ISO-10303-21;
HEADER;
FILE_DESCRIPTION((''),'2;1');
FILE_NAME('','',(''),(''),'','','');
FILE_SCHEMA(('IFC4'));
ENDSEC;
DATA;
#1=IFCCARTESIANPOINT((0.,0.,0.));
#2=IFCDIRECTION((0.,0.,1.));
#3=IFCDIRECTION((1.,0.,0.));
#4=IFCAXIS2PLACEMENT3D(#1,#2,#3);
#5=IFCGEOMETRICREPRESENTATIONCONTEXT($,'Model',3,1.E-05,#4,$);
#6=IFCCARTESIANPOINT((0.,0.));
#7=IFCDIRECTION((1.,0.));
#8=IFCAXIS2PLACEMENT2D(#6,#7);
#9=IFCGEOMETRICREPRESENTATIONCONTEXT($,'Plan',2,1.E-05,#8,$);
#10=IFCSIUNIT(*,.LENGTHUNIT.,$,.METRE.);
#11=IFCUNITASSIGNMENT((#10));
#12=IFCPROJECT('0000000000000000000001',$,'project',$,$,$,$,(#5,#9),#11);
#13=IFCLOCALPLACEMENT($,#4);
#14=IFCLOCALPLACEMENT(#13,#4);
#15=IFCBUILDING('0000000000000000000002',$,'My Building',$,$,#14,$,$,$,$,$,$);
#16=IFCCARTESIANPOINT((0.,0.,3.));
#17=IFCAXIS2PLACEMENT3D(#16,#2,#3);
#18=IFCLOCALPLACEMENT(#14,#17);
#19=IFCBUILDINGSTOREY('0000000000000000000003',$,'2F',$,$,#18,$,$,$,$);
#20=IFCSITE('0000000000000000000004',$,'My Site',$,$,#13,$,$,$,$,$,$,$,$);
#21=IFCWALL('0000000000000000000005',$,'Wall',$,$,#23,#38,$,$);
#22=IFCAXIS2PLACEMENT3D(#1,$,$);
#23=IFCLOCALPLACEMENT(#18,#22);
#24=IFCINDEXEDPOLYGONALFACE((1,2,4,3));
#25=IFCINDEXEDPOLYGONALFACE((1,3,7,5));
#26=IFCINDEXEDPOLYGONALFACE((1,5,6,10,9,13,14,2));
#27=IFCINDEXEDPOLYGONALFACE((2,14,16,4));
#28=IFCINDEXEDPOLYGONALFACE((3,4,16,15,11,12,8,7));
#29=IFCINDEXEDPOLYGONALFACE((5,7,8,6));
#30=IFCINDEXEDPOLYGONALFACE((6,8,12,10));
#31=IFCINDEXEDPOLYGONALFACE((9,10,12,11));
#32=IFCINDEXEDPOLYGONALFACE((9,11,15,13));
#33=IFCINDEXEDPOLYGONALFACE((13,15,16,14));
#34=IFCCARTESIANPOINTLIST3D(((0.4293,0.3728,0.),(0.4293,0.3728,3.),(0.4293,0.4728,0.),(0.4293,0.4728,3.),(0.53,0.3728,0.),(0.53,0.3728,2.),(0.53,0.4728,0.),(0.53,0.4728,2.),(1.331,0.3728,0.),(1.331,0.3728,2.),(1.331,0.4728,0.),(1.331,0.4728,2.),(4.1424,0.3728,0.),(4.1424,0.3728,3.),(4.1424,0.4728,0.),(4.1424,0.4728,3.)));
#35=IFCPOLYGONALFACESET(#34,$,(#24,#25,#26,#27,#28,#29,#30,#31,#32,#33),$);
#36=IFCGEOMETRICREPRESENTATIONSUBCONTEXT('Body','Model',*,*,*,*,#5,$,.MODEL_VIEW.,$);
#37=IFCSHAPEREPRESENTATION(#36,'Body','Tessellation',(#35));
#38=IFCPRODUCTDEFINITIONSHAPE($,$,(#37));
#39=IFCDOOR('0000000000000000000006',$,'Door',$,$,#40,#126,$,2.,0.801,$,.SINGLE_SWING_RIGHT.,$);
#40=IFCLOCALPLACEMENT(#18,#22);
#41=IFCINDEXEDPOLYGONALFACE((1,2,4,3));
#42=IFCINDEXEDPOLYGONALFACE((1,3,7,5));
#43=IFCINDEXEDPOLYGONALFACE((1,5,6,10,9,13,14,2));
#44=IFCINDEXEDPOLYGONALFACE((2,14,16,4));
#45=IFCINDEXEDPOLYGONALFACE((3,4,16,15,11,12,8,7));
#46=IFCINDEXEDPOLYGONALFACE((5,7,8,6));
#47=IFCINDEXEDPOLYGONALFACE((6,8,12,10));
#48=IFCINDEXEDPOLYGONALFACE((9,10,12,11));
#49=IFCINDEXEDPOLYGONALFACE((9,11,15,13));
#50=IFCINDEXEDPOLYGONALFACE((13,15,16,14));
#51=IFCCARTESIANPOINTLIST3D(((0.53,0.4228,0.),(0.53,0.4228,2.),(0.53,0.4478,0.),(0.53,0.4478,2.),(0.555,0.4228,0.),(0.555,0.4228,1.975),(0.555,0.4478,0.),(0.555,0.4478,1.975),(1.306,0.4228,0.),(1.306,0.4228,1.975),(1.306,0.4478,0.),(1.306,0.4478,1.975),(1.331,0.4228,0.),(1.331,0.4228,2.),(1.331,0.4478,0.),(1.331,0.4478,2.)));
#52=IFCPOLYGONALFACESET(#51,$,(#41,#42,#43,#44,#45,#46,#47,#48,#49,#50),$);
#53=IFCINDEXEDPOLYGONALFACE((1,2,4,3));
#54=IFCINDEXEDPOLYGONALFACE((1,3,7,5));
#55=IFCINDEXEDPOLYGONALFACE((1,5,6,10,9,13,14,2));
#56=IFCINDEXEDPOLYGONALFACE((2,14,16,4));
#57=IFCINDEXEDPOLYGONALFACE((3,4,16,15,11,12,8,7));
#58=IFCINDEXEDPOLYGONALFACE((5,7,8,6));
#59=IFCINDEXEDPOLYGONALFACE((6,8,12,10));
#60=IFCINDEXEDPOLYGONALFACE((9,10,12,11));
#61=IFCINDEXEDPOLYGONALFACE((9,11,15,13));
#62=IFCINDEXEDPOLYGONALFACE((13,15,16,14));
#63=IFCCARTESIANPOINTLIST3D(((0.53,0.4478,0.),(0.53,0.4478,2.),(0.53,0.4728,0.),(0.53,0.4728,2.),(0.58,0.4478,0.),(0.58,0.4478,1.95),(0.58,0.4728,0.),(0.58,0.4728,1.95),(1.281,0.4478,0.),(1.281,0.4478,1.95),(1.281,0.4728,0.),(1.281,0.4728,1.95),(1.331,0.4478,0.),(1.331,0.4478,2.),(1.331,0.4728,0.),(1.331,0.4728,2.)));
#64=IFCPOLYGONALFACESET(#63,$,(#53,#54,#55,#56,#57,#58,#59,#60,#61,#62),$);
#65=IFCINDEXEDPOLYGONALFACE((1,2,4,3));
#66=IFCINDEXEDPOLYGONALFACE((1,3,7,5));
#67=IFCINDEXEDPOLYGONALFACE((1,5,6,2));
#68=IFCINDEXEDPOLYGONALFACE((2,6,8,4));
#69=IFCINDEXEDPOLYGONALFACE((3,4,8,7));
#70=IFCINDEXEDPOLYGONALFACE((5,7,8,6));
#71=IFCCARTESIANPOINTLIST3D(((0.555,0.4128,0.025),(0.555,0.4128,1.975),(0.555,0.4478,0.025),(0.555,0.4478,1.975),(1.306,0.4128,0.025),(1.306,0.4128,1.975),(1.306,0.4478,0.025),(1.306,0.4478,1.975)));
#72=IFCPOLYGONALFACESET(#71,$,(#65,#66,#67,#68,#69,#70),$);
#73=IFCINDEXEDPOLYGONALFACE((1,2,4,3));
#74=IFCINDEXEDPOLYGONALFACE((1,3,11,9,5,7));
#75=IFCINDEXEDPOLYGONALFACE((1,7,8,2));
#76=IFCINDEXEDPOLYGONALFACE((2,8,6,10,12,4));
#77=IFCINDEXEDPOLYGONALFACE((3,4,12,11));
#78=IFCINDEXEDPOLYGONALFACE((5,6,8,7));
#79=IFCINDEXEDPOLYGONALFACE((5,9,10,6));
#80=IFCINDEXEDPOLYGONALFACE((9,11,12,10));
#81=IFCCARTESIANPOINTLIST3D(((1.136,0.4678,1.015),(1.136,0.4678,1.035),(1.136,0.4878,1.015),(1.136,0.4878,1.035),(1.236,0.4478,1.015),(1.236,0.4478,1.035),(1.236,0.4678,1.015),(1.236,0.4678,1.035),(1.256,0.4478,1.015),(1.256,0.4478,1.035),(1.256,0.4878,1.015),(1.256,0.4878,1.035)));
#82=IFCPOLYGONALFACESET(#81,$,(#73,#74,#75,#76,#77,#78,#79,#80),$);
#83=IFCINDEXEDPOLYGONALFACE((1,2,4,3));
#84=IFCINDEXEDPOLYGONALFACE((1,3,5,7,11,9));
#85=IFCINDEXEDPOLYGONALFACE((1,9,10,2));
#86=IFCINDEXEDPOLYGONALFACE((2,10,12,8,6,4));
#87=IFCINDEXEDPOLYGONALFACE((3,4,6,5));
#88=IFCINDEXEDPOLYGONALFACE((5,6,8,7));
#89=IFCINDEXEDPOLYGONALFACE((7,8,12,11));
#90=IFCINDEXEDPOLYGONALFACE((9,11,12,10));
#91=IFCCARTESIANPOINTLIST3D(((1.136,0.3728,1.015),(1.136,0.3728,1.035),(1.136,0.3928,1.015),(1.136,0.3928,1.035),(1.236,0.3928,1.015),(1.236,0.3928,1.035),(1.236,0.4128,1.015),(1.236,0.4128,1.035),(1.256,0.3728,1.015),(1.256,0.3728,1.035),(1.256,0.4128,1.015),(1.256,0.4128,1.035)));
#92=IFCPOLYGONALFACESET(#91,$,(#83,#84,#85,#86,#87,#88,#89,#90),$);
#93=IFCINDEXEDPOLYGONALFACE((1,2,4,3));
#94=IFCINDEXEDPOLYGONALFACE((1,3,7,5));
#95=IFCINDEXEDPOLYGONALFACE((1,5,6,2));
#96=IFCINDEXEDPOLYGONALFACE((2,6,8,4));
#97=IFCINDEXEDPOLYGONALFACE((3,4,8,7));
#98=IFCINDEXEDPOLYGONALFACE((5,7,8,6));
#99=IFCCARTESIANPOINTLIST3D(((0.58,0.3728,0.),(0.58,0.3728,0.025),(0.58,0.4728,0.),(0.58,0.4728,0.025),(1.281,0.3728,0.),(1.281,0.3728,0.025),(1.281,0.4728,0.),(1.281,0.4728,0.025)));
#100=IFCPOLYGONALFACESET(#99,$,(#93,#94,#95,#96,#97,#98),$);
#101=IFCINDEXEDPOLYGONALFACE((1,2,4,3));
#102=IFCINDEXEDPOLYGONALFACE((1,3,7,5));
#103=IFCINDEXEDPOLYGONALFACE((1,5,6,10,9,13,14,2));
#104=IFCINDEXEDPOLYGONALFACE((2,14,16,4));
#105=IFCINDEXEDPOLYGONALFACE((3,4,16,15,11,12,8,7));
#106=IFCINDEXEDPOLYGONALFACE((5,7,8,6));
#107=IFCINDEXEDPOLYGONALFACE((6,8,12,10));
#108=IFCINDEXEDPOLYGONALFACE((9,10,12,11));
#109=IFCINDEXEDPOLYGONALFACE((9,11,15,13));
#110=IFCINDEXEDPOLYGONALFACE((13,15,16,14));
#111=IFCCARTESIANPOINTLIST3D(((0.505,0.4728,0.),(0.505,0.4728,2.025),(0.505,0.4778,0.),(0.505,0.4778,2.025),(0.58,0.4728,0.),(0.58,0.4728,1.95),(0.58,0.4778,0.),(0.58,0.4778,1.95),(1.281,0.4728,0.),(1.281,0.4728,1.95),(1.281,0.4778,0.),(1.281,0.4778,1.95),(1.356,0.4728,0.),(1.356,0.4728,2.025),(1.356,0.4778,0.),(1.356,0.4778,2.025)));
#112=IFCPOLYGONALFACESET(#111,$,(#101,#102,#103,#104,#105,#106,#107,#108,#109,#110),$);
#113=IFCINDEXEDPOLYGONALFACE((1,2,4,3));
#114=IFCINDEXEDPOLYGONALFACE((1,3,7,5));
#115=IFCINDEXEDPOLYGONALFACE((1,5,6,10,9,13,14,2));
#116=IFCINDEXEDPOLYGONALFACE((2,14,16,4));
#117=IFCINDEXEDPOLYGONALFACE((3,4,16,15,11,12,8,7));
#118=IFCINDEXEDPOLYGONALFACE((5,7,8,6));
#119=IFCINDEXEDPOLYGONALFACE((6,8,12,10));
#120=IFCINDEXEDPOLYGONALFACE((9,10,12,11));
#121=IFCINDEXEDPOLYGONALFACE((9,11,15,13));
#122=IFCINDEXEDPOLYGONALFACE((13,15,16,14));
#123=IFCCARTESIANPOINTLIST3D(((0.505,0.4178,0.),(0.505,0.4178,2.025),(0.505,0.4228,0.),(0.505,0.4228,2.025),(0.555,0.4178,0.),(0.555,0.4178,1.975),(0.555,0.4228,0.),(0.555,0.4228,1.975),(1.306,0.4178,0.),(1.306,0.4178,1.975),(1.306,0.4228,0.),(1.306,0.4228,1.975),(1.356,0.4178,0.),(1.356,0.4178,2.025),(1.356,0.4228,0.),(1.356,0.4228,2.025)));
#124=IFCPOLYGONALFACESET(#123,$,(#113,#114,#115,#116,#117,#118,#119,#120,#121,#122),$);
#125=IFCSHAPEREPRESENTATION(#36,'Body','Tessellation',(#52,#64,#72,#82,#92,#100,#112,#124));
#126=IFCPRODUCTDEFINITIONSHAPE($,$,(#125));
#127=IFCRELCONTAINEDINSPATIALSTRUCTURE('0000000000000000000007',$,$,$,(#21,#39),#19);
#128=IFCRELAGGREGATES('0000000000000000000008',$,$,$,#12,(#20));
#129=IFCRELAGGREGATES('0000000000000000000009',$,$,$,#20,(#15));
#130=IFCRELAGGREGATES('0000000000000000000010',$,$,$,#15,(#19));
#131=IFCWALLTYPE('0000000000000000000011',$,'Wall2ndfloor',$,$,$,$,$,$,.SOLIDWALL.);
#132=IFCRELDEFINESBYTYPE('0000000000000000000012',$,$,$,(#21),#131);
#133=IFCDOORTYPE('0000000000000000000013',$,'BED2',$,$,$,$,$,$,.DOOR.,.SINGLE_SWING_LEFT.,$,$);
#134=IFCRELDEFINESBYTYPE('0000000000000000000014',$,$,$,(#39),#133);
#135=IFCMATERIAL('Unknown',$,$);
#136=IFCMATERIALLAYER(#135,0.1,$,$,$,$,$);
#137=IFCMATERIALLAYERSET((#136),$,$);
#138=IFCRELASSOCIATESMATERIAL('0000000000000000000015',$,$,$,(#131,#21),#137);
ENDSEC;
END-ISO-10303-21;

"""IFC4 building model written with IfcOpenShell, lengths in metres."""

from ifc_helpers import new_model, entity, si_unit, frame, origin_with_axes, origin_2d_with_axis, place, context, subcontext, project, spatial, line, indexed_curve, outline, extrude, shape, source, transform, mapped, material, layer, layer_set, layer_usage, type_object, type_shapes, element, fill, save


model = new_model("IFC4")

# Units and contexts
model_context = context("Model", 3, precision=1e-05, world=origin_with_axes())
plan_context = context("Plan", 2, precision=1e-05, world=origin_2d_with_axis())
body_context_1 = subcontext(model_context, "Body", "Model", "MODEL_VIEW")
body_context_2 = subcontext(plan_context, "Body", "Plan", "PLAN_VIEW")
ifc_project = project(units=[si_unit("LENGTHUNIT", "METRE")], contexts=[model_context, plan_context])

# Site, building, storey
site_placement = place(None, origin_with_axes())
site = spatial("IfcSite", under=ifc_project, at=site_placement, Name="My Site")
building_placement = place(site_placement, origin_with_axes())
building = spatial("IfcBuilding", under=site, at=building_placement, Name="My Building")
storey_placement = place(building_placement, frame((0.0, 0.0, 3.0), z_axis=(0.0, 0.0, 1.0), x_axis=(1.0, 0.0, 0.0)))
storey = spatial("IfcBuildingStorey", under=building, at=storey_placement, Name="2F")

# Shared definitions
ifc_material = material(Name="Unknown")

# Shared definitions
ifc_layer_1 = layer(ifc_material, 0.1)
ifc_layer_set_1 = layer_set([ifc_layer_1])
wall_type = type_object("IfcWallType", Name="Wall2ndfloor", PredefinedType="SOLIDWALL", material=ifc_layer_set_1)

# Wall, opening, door
ifc_layer_usage_1 = layer_usage(ifc_layer_set_1, "AXIS2", "POSITIVE", 0.0)
wall_1_placement = place(storey_placement, frame((0.4293, 0.3728, 0.0), z_axis=(0.0, 0.0, 1.0), x_axis=(1.0, 0.0, 0.0)))
wall_1 = element("IfcWall", 1, at=wall_1_placement, inside=storey, type_object=wall_type, material=ifc_layer_usage_1, Name="Wall", context=body_context_1, shape_type="SweptSolid", body=[
    extrude(outline(indexed_curve([(0.0, 0.0), (0.0, 0.1), (3.7131, 0.1), (3.7131, 0.0)], segments=[line(1, 2, 3, 4, 1)])), origin_with_axes(), (0.0, 0.0, 1.0), 3.0),
])
shared_shape_1 = source(origin_with_axes(), body_context_1, "Body", "SweptSolid", [
    extrude(outline(indexed_curve([(0.0, 0.0), (0.801, 0.0), (0.801, 2.0), (0.0, 2.0)], segments=[line(1, 2, 3, 4, 1)])), frame((0.0, -0.6, 0.0), z_axis=(0.0, -1.0, 0.0), x_axis=(1.0, 0.0, 0.0)), (0.0, 0.0, -1.0), 1.2),
])
opening_1_placement = place(wall_1_placement, frame((0.9017, 0.1, 0.0), z_axis=(0.0, 0.0, 1.0), x_axis=(-1.0, 0.0, 0.0)))
opening_1 = element("IfcOpeningElement", 2, at=opening_1_placement, cuts=wall_1, PredefinedType="OPENING", context=body_context_1, shape_type="MappedRepresentation", body=[
    mapped(shared_shape_1, transform((0.0, 0.0, 0.0), x_axis=(1.0, 0.0, 0.0), y_axis=(0.0, 1.0, 0.0), z_axis=(0.0, 0.0, 1.0), scale=1.0)),
])
door_type_1 = type_object("IfcDoorType", Name="BED2", OperationType="SINGLE_SWING_LEFT", PredefinedType="DOOR")
shared_shape_2 = source(origin_with_axes(), body_context_1, "Body", "SweptSolid", [
    extrude(outline(indexed_curve([(0.0, 0.0), (0.0, 2.0), (0.801, 2.0), (0.801, 0.0), (0.776, 0.0), (0.776, 1.975), (0.025, 1.975), (0.025, 0.0)], segments=[line(1, 2, 3, 4, 5, 6, 7, 8, 1)])), frame((0.0, 0.025, 0.0), z_axis=(0.0, -1.0, 0.0), x_axis=(1.0, 0.0, 0.0)), (0.0, 0.0, -1.0), 0.025),
    extrude(outline(indexed_curve([(0.0, 0.0), (0.0, 2.0), (0.801, 2.0), (0.801, 0.0), (0.751, 0.0), (0.751, 1.95), (0.05, 1.95), (0.05, 0.0)], segments=[line(1, 2, 3, 4, 5, 6, 7, 8, 1)])), frame((0.0, 0.0, 0.0), z_axis=(0.0, -1.0, 0.0), x_axis=(1.0, 0.0, 0.0)), (0.0, 0.0, -1.0), 0.025),
    extrude(outline(indexed_curve([(0.0, 0.0), (0.751, 0.0), (0.751, 0.035), (0.0, 0.035)], segments=[line(1, 2, 3, 4, 1)])), frame((0.025, 0.025, 0.025), z_axis=(0.0, 0.0, 1.0), x_axis=(1.0, 0.0, 0.0)), (0.0, 0.0, 1.0), 1.95),
    extrude(outline(indexed_curve([(0.0, 0.0), (0.0, -0.04), (0.12, -0.04), (0.12, -0.02), (0.02, -0.02), (0.02, 0.0)], segments=[line(1, 2, 3, 4, 5, 6, 1)])), frame((0.075, 0.025, 1.015), z_axis=(0.0, 0.0, 1.0), x_axis=(1.0, 0.0, 0.0)), (0.0, 0.0, 1.0), 0.02),
    extrude(outline(indexed_curve([(0.0, 0.0), (0.0, 0.04), (0.12, 0.04), (0.12, 0.02), (0.02, 0.02), (0.02, 0.0)], segments=[line(1, 2, 3, 4, 5, 6, 1)])), frame((0.075, 0.06, 1.015), z_axis=(0.0, 0.0, 1.0), x_axis=(1.0, 0.0, 0.0)), (0.0, 0.0, 1.0), 0.02),
    extrude(outline(indexed_curve([(0.0, 0.0), (0.701, 0.0), (0.701, 0.1), (0.0, 0.1)], segments=[line(1, 2, 3, 4, 1)])), frame((0.05, 0.0, 0.0), z_axis=(0.0, 0.0, 1.0), x_axis=(1.0, 0.0, 0.0)), (0.0, 0.0, 1.0), 0.025),
    extrude(outline(indexed_curve([(0.0, 0.0), (0.0, 2.025), (0.851, 2.025), (0.851, 0.0), (0.776, 0.0), (0.776, 1.95), (0.075, 1.95), (0.075, 0.0)], segments=[line(1, 2, 3, 4, 5, 6, 7, 8, 1)])), frame((-0.025, -0.005, 0.0), z_axis=(0.0, -1.0, 0.0), x_axis=(1.0, 0.0, 0.0)), (0.0, 0.0, -1.0), 0.005),
    extrude(outline(indexed_curve([(0.0, 0.0), (0.0, 2.025), (0.851, 2.025), (0.851, 0.0), (0.801, 0.0), (0.801, 1.975), (0.05, 1.975), (0.05, 0.0)], segments=[line(1, 2, 3, 4, 5, 6, 7, 8, 1)])), frame((-0.025, 0.05, 0.0), z_axis=(0.0, -1.0, 0.0), x_axis=(1.0, 0.0, 0.0)), (0.0, 0.0, -1.0), 0.005),
])
shared_shape_3 = source(origin_with_axes(), body_context_2, "Body", "Curve2D", [
    entity("IfcIndexedPolyCurve", entity("IfcCartesianPointList2D", [[0.0, 0.0], [0.0, 0.05], [0.025, 0.05], [0.025, 0.025], [0.05, 0.025], [0.05, 0.0]]), [entity("IfcLineIndex", [1, 2, 3, 4, 5, 6, 1])]),
    entity("IfcIndexedPolyCurve", entity("IfcCartesianPointList2D", [[0.801, 0.0], [0.801, 0.05], [0.776, 0.05], [0.776, 0.025], [0.751, 0.025], [0.751, 0.0]]), [entity("IfcLineIndex", [1, 2, 3, 4, 5, 6, 1])]),
    entity("IfcTrimmedCurve", entity("IfcEllipse", entity("IfcAxis2Placement2D", entity("IfcCartesianPoint", [0.741, 0.05]), entity("IfcDirection", [1.0, 0.0])), 0.716, 0.751), [entity("IfcCartesianPoint", [0.741, 0.801])], [entity("IfcCartesianPoint", [0.025, 0.05])], True, "CARTESIAN"),
    entity("IfcIndexedPolyCurve", entity("IfcCartesianPointList2D", [[0.776, 0.05], [0.741, 0.05], [0.741, 0.801], [0.776, 0.801]]), [entity("IfcLineIndex", [1, 2, 3, 4, 1])]),
])
type_shapes(door_type_1, [shared_shape_2, shared_shape_3])
door_1_placement = place(opening_1_placement, origin_with_axes())
door_1 = element("IfcDoor", 3, at=door_1_placement, inside=storey, type_object=door_type_1, Name="Door", OperationType="SINGLE_SWING_RIGHT", OverallHeight=2.0, OverallWidth=0.801, shapes=[
    shape(body_context_1, "Body", "MappedRepresentation", [mapped(shared_shape_2, transform((0.0, 0.0, 0.0), x_axis=(1.0, 0.0, 0.0), y_axis=(0.0, 1.0, 0.0), z_axis=(0.0, 0.0, 1.0), scale=1.0))]),
    shape(body_context_2, "Body", "MappedRepresentation", [mapped(shared_shape_3, transform((0.0, 0.0, 0.0), x_axis=(1.0, 0.0, 0.0), y_axis=(0.0, 1.0, 0.0), z_axis=(0.0, 0.0, 1.0), scale=1.0))]),
])
fill(opening_1, door_1)

save(model, "model.ifc")
